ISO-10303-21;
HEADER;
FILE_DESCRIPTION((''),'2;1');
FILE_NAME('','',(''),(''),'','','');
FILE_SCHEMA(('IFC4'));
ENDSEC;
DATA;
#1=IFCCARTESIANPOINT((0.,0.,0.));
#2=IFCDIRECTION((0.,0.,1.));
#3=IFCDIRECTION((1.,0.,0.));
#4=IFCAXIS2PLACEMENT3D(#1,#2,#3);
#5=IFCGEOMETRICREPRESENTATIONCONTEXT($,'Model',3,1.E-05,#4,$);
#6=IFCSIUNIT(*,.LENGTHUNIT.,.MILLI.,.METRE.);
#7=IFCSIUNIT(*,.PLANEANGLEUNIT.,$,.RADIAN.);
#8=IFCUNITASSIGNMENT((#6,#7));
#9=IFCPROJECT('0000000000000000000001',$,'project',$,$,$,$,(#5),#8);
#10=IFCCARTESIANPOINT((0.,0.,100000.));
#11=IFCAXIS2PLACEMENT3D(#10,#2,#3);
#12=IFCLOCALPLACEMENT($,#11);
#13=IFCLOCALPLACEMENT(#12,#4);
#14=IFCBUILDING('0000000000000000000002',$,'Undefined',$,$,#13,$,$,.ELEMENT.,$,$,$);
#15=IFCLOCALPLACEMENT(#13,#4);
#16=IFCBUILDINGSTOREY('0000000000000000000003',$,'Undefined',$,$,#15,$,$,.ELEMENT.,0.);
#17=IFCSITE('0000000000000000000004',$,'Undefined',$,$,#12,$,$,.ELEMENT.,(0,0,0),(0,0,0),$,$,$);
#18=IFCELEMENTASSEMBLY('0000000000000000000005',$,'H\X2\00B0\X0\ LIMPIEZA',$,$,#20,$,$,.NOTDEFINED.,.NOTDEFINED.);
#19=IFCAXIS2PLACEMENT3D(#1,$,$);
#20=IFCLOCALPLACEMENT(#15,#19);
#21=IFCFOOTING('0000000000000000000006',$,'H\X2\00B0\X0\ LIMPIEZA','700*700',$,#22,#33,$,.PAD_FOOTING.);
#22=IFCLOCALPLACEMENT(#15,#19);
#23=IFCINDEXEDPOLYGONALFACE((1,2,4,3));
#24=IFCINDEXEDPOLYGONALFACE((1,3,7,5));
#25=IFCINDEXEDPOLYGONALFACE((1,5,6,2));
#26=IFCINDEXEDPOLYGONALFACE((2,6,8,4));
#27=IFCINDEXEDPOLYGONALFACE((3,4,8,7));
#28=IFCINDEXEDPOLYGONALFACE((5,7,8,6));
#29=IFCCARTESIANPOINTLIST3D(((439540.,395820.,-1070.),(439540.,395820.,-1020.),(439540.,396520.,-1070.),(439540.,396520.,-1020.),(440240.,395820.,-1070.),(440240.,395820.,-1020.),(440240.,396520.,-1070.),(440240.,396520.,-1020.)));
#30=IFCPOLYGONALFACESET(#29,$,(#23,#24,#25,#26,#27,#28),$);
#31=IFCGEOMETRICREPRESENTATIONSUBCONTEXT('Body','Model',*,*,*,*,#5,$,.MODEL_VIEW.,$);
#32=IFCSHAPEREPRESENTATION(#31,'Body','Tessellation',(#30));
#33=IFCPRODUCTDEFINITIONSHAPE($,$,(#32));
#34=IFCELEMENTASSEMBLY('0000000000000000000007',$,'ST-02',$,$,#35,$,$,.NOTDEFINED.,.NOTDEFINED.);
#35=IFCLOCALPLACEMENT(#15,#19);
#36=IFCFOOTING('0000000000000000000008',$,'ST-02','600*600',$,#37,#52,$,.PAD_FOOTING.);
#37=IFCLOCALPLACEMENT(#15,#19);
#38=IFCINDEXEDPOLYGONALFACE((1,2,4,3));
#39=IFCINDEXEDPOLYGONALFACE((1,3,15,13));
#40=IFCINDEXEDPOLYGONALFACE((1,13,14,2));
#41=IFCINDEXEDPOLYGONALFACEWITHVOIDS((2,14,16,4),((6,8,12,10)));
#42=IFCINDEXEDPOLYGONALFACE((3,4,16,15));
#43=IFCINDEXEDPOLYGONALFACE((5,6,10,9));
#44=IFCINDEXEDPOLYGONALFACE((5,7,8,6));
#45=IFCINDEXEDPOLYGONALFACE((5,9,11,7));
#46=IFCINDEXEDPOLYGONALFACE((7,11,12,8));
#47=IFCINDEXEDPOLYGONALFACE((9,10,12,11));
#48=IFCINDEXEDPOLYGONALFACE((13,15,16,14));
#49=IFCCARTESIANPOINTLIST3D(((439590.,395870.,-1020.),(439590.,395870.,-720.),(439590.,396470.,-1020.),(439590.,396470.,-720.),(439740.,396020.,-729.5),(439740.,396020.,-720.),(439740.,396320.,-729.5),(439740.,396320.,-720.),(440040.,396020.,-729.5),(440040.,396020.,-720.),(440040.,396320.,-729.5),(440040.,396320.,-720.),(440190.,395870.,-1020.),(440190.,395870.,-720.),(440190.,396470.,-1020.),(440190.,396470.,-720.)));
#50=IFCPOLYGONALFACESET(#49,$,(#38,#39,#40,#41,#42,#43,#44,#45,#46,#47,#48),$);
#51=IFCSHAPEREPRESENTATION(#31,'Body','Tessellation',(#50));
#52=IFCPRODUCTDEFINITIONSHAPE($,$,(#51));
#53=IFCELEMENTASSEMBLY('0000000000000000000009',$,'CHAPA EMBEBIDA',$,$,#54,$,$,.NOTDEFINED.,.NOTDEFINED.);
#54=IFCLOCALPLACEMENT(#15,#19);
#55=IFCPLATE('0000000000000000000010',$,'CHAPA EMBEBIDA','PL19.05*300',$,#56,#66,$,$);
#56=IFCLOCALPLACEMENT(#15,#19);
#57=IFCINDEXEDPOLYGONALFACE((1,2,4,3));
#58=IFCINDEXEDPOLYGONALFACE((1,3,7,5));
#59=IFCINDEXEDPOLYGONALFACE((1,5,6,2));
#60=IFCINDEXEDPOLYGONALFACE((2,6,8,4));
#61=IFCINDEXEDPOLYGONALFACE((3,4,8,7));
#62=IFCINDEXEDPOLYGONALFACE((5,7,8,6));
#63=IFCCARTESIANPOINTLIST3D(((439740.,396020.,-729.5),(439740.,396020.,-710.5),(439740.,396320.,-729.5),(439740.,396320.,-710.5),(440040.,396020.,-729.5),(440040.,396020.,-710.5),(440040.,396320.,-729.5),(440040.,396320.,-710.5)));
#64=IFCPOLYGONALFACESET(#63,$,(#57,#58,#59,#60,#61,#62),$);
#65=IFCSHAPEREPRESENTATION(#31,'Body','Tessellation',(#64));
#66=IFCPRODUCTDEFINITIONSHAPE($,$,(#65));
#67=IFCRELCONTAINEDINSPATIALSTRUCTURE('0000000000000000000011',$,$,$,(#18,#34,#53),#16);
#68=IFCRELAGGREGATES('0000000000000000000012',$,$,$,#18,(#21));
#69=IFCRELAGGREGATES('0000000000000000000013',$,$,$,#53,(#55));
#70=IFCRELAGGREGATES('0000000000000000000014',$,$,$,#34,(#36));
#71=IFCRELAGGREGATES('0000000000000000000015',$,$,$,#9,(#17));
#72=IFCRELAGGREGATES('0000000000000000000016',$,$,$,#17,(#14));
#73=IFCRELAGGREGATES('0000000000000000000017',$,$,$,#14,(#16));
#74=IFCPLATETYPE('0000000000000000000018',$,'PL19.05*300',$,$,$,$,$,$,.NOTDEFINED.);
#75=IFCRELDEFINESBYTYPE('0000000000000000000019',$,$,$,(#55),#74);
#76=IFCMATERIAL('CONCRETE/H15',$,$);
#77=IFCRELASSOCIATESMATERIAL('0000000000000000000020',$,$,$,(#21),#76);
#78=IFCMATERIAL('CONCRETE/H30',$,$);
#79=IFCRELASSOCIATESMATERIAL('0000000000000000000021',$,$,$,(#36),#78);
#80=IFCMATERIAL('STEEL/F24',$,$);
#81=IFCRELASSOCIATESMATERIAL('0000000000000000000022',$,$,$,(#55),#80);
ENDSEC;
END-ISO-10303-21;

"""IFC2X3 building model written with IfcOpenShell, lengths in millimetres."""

from ifc_helpers import new_model, si_unit, frame, origin_with_axes, origin_2d_with_axis, place, context, subcontext, project, spatial, polyline, rectangle, outline, extrude, boolean, material, type_object, element, aggregate, save


model = new_model("IFC2X3")

# Units and contexts
model_context = context("Model", 3, precision=1e-05, world=origin_with_axes())
body_context = subcontext(model_context, "Body", "Model", "MODEL_VIEW")
ifc_project = project(units=[si_unit("LENGTHUNIT", "METRE", prefix="MILLI"), si_unit("PLANEANGLEUNIT", "RADIAN")], contexts=[model_context])

# Site, building, storey
site_placement = place(None, frame((0.0, 0.0, 100000.0), z_axis=(0.0, 0.0, 1.0), x_axis=(1.0, 0.0, 0.0)))
site = spatial("IfcSite", under=ifc_project, at=site_placement, Name="Undefined", CompositionType="ELEMENT", RefLatitude=(0, 0, 0), RefLongitude=(0, 0, 0))
building_placement = place(site_placement, origin_with_axes())
building = spatial("IfcBuilding", under=site, at=building_placement, Name="Undefined", CompositionType="ELEMENT")
storey_placement = place(building_placement, origin_with_axes())
storey = spatial("IfcBuildingStorey", under=building, at=storey_placement, Name="Undefined", CompositionType="ELEMENT", Elevation=0.0)

# Element assemblies, footings
assembly_1_placement = place(storey_placement, origin_with_axes())
assembly_1 = element("IfcElementAssembly", 1, at=assembly_1_placement, inside=storey, Name="H° LIMPIEZA", AssemblyPlace="NOTDEFINED", PredefinedType="NOTDEFINED")
ifc_material_1 = material(Name="CONCRETE/H15")
footing_1_placement = place(assembly_1_placement, frame((439890.0, 396170.0, -1070.0), z_axis=(0.0, 1.0, 0.0), x_axis=(0.0, 0.0, 1.0)))
footing_1 = element("IfcFooting", 2, at=footing_1_placement, material=ifc_material_1, Name="H° LIMPIEZA", Description="700*700", PredefinedType="PAD_FOOTING", context=body_context, shape_type="SweptSolid", body=[
    extrude(rectangle(XDim=700.0, YDim=700.0, at=origin_2d_with_axis()), frame((50.0, 0.0, 0.0), z_axis=(-1.0, 0.0, 0.0), x_axis=(0.0, -1.0, 0.0)), (0.0, 0.0, 1.0), 50.0),
])
aggregate(assembly_1, [footing_1])
assembly_2_placement = place(storey_placement, origin_with_axes())
assembly_2 = element("IfcElementAssembly", 3, at=assembly_2_placement, inside=storey, Name="ST-02", AssemblyPlace="NOTDEFINED", PredefinedType="NOTDEFINED")
ifc_material_2 = material(Name="CONCRETE/H30")
footing_2_placement = place(assembly_2_placement, frame((439890.0, 396170.0, -1020.0), z_axis=(0.0, 1.0, 0.0), x_axis=(0.0, 0.0, 1.0)))
footing_2 = element("IfcFooting", 4, at=footing_2_placement, material=ifc_material_2, Name="ST-02", Description="600*600", PredefinedType="PAD_FOOTING", context=body_context, shape_type="CSG", body=[
    boolean("DIFFERENCE", extrude(rectangle(XDim=600.0, YDim=600.0, at=origin_2d_with_axis()), frame((300.0, 0.0, 0.0), z_axis=(-1.0, 0.0, 0.0), x_axis=(0.0, -1.0, 0.0)), (0.0, 0.0, 1.0), 300.0), extrude(outline(polyline([(0.0, 0.0), (300.0, 0.0), (300.0, 300.0), (0.0, 300.0), (0.0, 0.0)])), frame((290.5, -150.0, -150.0), z_axis=(1.0, 0.0, 0.0), x_axis=(0.0, 1.0, 0.0)), (0.0, 0.0, 1.0), 19.1)),
])

# Element assembly, plate
assembly_3_placement = place(storey_placement, origin_with_axes())
assembly_3 = element("IfcElementAssembly", 5, at=assembly_3_placement, inside=storey, Name="CHAPA EMBEBIDA", AssemblyPlace="NOTDEFINED", PredefinedType="NOTDEFINED")
ifc_material_3 = material(Name="STEEL/F24")
plate_type = type_object("IfcPlateType", Name="PL19.05*300", PredefinedType="NOTDEFINED")
plate_placement = place(assembly_3_placement, frame((439740.0, 396020.0, -720.0), z_axis=(0.0, 0.0, 1.0), x_axis=(1.0, 0.0, 0.0)))
plate = element("IfcPlate", 6, at=plate_placement, type_object=plate_type, material=ifc_material_3, Name="CHAPA EMBEBIDA", Description="PL19.05*300", context=body_context, shape_type="SweptSolid", body=[
    extrude(outline(polyline([(0.0, 0.0), (300.0, 0.0), (300.0, 300.0), (0.0, 300.0), (0.0, 0.0)])), frame((0.0, 0.0, -9.5), z_axis=(0.0, 0.0, 1.0), x_axis=(1.0, 0.0, 0.0)), (0.0, 0.0, 1.0), 19.1),
])
aggregate(assembly_3, [plate])

aggregate(assembly_2, [footing_2])

save(model, "model.ifc")
